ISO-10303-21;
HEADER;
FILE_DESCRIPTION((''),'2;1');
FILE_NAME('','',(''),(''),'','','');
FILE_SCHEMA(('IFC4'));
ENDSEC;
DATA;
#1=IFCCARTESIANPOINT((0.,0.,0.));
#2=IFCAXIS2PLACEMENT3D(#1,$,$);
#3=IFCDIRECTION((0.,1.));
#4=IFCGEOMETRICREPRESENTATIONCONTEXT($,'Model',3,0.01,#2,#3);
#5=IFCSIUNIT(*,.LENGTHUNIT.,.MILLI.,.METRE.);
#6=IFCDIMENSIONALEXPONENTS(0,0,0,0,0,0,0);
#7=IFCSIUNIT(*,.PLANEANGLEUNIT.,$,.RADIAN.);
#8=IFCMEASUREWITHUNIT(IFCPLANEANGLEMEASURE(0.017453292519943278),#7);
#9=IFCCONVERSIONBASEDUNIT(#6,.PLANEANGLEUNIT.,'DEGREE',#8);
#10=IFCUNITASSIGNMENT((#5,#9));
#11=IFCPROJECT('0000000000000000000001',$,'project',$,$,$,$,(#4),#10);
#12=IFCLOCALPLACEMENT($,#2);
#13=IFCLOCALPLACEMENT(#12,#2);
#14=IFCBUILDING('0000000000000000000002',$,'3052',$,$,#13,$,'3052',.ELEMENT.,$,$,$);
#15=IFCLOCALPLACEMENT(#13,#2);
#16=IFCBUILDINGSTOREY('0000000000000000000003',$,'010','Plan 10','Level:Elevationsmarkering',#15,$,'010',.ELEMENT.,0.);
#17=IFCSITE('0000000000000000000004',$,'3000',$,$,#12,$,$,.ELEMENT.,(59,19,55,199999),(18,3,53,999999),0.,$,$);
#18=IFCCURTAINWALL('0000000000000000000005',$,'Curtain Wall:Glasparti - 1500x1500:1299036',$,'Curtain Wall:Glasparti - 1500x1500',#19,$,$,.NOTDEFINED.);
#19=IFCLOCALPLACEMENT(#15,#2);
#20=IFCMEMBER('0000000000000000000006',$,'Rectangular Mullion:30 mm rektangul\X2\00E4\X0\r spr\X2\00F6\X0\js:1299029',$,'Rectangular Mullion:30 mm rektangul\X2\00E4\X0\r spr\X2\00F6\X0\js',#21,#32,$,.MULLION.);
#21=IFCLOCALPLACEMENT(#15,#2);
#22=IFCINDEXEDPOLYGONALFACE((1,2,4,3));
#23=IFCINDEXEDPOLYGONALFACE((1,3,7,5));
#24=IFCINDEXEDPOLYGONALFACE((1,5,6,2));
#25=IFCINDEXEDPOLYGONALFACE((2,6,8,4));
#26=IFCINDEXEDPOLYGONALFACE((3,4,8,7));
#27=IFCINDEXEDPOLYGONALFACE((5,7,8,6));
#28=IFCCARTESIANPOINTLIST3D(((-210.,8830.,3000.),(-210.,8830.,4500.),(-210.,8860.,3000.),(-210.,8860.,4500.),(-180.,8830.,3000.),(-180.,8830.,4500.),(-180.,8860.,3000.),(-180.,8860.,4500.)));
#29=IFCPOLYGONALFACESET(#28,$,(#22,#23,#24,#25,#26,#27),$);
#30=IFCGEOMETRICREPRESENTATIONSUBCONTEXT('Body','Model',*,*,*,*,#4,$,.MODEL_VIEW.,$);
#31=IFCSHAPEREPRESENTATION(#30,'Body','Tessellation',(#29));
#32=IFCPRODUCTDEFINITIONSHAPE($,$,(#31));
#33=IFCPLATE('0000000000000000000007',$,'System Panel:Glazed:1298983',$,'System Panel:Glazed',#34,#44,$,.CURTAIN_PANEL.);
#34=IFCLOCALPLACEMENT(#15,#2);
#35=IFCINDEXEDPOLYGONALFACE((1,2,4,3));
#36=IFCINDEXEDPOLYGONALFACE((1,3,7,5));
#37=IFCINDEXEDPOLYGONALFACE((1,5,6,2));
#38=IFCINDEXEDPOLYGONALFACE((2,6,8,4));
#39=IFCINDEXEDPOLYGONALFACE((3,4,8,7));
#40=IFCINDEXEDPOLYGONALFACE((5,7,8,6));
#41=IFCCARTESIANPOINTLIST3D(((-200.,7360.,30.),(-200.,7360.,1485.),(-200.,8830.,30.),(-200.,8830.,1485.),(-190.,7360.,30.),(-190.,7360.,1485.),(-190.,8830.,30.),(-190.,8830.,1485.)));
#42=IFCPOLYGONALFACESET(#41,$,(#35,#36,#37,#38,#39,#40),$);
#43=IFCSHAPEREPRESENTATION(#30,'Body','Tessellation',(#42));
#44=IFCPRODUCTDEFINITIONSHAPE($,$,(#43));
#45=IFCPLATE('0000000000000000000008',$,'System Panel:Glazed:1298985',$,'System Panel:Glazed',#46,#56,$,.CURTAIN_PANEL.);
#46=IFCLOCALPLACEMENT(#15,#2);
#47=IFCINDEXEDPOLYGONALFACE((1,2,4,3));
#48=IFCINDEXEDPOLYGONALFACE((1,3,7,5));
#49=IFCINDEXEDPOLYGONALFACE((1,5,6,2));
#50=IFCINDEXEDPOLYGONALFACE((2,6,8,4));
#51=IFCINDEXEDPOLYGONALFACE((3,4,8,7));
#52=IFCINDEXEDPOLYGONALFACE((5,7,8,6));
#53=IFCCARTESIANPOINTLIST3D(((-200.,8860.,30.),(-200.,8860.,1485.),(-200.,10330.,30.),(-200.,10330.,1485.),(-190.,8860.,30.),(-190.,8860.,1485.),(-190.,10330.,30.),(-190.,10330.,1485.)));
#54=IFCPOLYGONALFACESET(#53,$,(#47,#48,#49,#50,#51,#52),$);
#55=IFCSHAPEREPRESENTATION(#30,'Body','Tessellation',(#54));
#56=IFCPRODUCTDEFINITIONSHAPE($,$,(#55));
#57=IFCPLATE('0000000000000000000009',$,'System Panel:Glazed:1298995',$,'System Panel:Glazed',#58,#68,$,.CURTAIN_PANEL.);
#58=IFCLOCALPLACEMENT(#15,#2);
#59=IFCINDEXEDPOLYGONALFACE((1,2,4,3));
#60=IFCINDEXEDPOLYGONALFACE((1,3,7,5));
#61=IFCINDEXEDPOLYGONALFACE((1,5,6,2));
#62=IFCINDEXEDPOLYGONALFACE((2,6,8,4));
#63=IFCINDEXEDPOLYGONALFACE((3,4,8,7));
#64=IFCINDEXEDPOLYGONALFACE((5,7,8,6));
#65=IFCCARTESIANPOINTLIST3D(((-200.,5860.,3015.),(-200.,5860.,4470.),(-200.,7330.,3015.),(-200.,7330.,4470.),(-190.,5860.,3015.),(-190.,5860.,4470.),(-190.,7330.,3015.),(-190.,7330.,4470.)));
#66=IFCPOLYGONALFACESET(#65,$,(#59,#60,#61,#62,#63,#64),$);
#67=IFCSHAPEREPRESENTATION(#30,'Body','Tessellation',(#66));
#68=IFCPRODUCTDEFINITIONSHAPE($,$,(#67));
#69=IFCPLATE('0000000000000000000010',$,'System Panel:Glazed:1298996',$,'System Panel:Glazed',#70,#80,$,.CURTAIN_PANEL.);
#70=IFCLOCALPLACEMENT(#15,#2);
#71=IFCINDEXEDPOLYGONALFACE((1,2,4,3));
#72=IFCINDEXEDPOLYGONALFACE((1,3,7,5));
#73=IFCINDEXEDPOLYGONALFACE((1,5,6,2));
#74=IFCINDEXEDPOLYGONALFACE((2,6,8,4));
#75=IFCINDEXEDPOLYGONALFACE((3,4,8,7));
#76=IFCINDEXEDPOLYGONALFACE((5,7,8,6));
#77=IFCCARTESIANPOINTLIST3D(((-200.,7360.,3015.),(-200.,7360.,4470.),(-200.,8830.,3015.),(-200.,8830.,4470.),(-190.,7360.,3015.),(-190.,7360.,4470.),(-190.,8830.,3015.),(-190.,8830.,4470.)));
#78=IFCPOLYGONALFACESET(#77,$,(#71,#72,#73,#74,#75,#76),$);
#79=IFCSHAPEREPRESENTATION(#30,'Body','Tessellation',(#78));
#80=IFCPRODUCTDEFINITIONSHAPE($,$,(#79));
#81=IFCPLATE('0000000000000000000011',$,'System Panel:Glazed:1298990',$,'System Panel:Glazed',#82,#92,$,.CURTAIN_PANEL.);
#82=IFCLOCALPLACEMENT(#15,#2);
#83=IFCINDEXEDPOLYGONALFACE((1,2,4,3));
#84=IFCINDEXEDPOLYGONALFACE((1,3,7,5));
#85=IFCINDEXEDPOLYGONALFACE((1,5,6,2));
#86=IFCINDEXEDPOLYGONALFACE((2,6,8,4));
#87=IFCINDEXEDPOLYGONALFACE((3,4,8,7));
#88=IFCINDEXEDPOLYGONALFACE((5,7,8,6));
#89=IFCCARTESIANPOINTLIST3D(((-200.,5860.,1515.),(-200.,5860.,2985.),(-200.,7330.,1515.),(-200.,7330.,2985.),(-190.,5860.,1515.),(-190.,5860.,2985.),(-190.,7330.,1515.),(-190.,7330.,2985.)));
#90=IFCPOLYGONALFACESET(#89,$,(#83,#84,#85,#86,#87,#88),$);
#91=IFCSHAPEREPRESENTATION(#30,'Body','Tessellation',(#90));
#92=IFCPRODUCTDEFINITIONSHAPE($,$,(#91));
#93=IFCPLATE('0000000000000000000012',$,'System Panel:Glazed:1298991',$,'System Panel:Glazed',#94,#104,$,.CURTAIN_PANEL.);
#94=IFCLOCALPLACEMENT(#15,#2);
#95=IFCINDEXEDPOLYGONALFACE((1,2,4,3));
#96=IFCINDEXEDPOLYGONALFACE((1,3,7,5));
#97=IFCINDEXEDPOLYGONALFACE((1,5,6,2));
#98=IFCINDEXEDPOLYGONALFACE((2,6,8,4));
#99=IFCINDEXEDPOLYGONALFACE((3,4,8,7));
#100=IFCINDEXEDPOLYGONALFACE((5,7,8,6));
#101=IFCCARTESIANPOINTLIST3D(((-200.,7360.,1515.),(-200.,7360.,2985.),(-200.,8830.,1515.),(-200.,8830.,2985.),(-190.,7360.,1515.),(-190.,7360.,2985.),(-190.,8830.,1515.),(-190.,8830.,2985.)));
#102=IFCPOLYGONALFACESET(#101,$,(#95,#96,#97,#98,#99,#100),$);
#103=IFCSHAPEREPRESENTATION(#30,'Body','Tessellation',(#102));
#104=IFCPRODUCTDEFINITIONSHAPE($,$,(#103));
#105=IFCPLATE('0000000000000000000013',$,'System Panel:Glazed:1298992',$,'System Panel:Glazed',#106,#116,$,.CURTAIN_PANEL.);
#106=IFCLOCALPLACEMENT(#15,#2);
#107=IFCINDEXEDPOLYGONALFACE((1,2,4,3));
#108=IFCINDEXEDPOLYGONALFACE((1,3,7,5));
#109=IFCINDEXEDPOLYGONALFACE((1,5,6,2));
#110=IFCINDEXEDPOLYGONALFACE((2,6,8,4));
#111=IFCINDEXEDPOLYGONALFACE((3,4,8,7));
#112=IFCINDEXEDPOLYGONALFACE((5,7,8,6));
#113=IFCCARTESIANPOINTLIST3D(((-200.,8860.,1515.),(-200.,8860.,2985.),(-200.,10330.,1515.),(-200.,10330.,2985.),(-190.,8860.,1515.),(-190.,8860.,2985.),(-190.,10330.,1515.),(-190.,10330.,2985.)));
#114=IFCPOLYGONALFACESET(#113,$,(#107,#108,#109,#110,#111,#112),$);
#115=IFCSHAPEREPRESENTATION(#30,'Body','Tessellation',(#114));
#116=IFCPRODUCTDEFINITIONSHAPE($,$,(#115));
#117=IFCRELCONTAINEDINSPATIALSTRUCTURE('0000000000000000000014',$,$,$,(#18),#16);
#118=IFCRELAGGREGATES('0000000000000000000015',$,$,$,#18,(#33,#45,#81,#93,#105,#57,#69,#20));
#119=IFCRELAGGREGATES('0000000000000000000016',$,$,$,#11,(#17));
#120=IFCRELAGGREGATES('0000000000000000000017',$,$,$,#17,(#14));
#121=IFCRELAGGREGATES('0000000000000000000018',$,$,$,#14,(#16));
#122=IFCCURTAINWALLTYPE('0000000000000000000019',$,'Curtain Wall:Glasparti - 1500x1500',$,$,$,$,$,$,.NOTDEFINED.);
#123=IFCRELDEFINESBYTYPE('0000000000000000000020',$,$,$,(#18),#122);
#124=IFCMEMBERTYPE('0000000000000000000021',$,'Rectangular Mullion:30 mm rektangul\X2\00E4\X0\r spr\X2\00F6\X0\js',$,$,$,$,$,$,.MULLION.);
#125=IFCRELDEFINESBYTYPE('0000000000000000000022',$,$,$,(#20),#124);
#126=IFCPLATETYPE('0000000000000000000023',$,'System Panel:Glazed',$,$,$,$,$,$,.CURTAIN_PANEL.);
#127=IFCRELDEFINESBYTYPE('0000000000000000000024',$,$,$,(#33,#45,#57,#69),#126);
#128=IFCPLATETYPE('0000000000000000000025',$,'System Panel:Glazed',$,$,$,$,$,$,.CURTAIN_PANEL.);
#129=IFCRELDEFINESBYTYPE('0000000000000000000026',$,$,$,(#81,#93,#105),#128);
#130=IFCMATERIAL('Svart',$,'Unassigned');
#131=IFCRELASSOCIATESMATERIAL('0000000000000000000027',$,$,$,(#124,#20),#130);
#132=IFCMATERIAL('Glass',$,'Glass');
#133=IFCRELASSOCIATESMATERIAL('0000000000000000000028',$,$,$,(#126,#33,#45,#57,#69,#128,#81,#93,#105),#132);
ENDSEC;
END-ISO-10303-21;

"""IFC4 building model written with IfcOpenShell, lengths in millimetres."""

from ifc_helpers import new_model, entity, si_unit, converted_unit, direction, frame, origin, place, context, subcontext, project, spatial, indexed_curve, outline, extrude, source, transform, mapped, material, type_object, type_shapes, element, aggregate, save


model = new_model("IFC4")

# Units and contexts
model_context = context("Model", 3, precision=0.01, world=origin(), true_north=direction((0.0, 1.0)))
body_context = subcontext(model_context, "Body", "Model", "MODEL_VIEW")
ifc_project = project(units=[si_unit("LENGTHUNIT", "METRE", prefix="MILLI"), converted_unit("PLANEANGLEUNIT", "DEGREE", entity("IfcPlaneAngleMeasure", 0.017453292519943278), si_unit("PLANEANGLEUNIT", "RADIAN"), dimensions=[0, 0, 0, 0, 0, 0, 0])], contexts=[model_context])

# Site, building, storey
site_placement = place(None, origin())
site = spatial("IfcSite", under=ifc_project, at=site_placement, Name="3000", CompositionType="ELEMENT", RefLatitude=(59, 19, 55, 199999), RefLongitude=(18, 3, 53, 999999), RefElevation=0.0)
building_placement = place(site_placement, origin())
building = spatial("IfcBuilding", under=site, at=building_placement, Name="3052", LongName="3052", CompositionType="ELEMENT")
storey_placement = place(building_placement, origin())
storey = spatial("IfcBuildingStorey", under=building, at=storey_placement, Name="010", Description="Plan 10", ObjectType="Level:Elevationsmarkering", LongName="010", CompositionType="ELEMENT", Elevation=0.0)

# Curtain wall, member, plates
curtain_wall_type = type_object("IfcCurtainWallType", Name="Curtain Wall:Glasparti - 1500x1500", PredefinedType="NOTDEFINED")
curtain_wall_placement = place(storey_placement, origin())
curtain_wall = element("IfcCurtainWall", 1, at=curtain_wall_placement, inside=storey, type_object=curtain_wall_type, Name="Curtain Wall:Glasparti - 1500x1500:1299036", ObjectType="Curtain Wall:Glasparti - 1500x1500", PredefinedType="NOTDEFINED")
ifc_material_1 = material(Name="Svart", Category="Unassigned")
member_type_1 = type_object("IfcMemberType", Name="Rectangular Mullion:30 mm rektangulär spröjs", PredefinedType="MULLION", material=ifc_material_1)
shared_shape_1 = source(origin(), body_context, "Body", "SweptSolid", [
    extrude(outline(indexed_curve([(-15.0, -15.0), (15.0, -15.0), (15.0, 15.0), (-15.0, 15.0), (-15.0, -15.0)], self_intersect=False)), frame((0.0, 0.0, -1500.0), z_axis=(0.0, 0.0, 1.0), x_axis=(-1.0, 0.0, 0.0)), (0.0, 0.0, 1.0), 1500.0),
])
type_shapes(member_type_1, [shared_shape_1])
member_1_placement = place(curtain_wall_placement, frame((-195.0, 8845.0, 3000.0), z_axis=(0.0, 0.0, -1.0), x_axis=(0.0, 1.0, 0.0)))
member_1 = element("IfcMember", 2, at=member_1_placement, type_object=member_type_1, material=ifc_material_1, Name="Rectangular Mullion:30 mm rektangulär spröjs:1299029", ObjectType="Rectangular Mullion:30 mm rektangulär spröjs", PredefinedType="MULLION", context=body_context, shape_type="MappedRepresentation", body=[
    mapped(shared_shape_1, transform((0.0, 0.0, 0.0), scale=1.0)),
])
ifc_material_2 = material(Name="Glass", Category="Glass")
plate_type_1 = type_object("IfcPlateType", Name="System Panel:Glazed", PredefinedType="CURTAIN_PANEL", material=ifc_material_2)
shared_shape_2 = source(origin(), body_context, "Body", "SweptSolid", [
    extrude(outline(indexed_curve([(-5.0, -735.0), (5.0, -735.0), (5.0, 735.0), (-5.0, 735.0), (-5.0, -735.0)], self_intersect=False)), frame((0.0, 0.0, 0.0), z_axis=(0.0, 0.0, 1.0), x_axis=(0.0, 1.0, 0.0)), (0.0, 0.0, 1.0), 1455.0),
])
type_shapes(plate_type_1, [shared_shape_2])
plate_1_placement = place(curtain_wall_placement, frame((-195.0, 8095.0, 30.0), z_axis=(0.0, 0.0, 1.0), x_axis=(0.0, 1.0, 0.0)))
plate_1 = element("IfcPlate", 3, at=plate_1_placement, type_object=plate_type_1, material=ifc_material_2, Name="System Panel:Glazed:1298983", ObjectType="System Panel:Glazed", PredefinedType="CURTAIN_PANEL", context=body_context, shape_type="MappedRepresentation", body=[
    mapped(shared_shape_2, transform((0.0, 0.0, 0.0), scale=1.0)),
])
plate_2_placement = place(curtain_wall_placement, frame((-195.0, 9595.0, 30.0), z_axis=(0.0, 0.0, 1.0), x_axis=(0.0, 1.0, 0.0)))
plate_2 = element("IfcPlate", 4, at=plate_2_placement, type_object=plate_type_1, material=ifc_material_2, Name="System Panel:Glazed:1298985", ObjectType="System Panel:Glazed", PredefinedType="CURTAIN_PANEL", context=body_context, shape_type="MappedRepresentation", body=[
    mapped(shared_shape_2, transform((0.0, 0.0, 0.0), scale=1.0)),
])
plate_3_placement = place(curtain_wall_placement, frame((-195.0, 6595.0, 3015.0), z_axis=(0.0, 0.0, 1.0), x_axis=(0.0, 1.0, 0.0)))
plate_3 = element("IfcPlate", 5, at=plate_3_placement, type_object=plate_type_1, material=ifc_material_2, Name="System Panel:Glazed:1298995", ObjectType="System Panel:Glazed", PredefinedType="CURTAIN_PANEL", context=body_context, shape_type="MappedRepresentation", body=[
    mapped(shared_shape_2, transform((0.0, 0.0, 0.0), scale=1.0)),
])
plate_4_placement = place(curtain_wall_placement, frame((-195.0, 8095.0, 3015.0), z_axis=(0.0, 0.0, 1.0), x_axis=(0.0, 1.0, 0.0)))
plate_4 = element("IfcPlate", 6, at=plate_4_placement, type_object=plate_type_1, material=ifc_material_2, Name="System Panel:Glazed:1298996", ObjectType="System Panel:Glazed", PredefinedType="CURTAIN_PANEL", context=body_context, shape_type="MappedRepresentation", body=[
    mapped(shared_shape_2, transform((0.0, 0.0, 0.0), scale=1.0)),
])
plate_type_2 = type_object("IfcPlateType", Name="System Panel:Glazed", PredefinedType="CURTAIN_PANEL", material=ifc_material_2)
shared_shape_3 = source(origin(), body_context, "Body", "SweptSolid", [
    extrude(outline(indexed_curve([(-5.0, -735.0), (5.0, -735.0), (5.0, 735.0), (-5.0, 735.0), (-5.0, -735.0)], self_intersect=False)), frame((0.0, 0.0, 0.0), z_axis=(0.0, 0.0, 1.0), x_axis=(0.0, 1.0, 0.0)), (0.0, 0.0, 1.0), 1470.0),
])
type_shapes(plate_type_2, [shared_shape_3])
plate_5_placement = place(curtain_wall_placement, frame((-195.0, 6595.0, 1515.0), z_axis=(0.0, 0.0, 1.0), x_axis=(0.0, 1.0, 0.0)))
plate_5 = element("IfcPlate", 7, at=plate_5_placement, type_object=plate_type_2, material=ifc_material_2, Name="System Panel:Glazed:1298990", ObjectType="System Panel:Glazed", PredefinedType="CURTAIN_PANEL", context=body_context, shape_type="MappedRepresentation", body=[
    mapped(shared_shape_3, transform((0.0, 0.0, 0.0), scale=1.0)),
])
plate_6_placement = place(curtain_wall_placement, frame((-195.0, 8095.0, 1515.0), z_axis=(0.0, 0.0, 1.0), x_axis=(0.0, 1.0, 0.0)))
plate_6 = element("IfcPlate", 8, at=plate_6_placement, type_object=plate_type_2, material=ifc_material_2, Name="System Panel:Glazed:1298991", ObjectType="System Panel:Glazed", PredefinedType="CURTAIN_PANEL", context=body_context, shape_type="MappedRepresentation", body=[
    mapped(shared_shape_3, transform((0.0, 0.0, 0.0), scale=1.0)),
])
plate_7_placement = place(curtain_wall_placement, frame((-195.0, 9595.0, 1515.0), z_axis=(0.0, 0.0, 1.0), x_axis=(0.0, 1.0, 0.0)))
plate_7 = element("IfcPlate", 9, at=plate_7_placement, type_object=plate_type_2, material=ifc_material_2, Name="System Panel:Glazed:1298992", ObjectType="System Panel:Glazed", PredefinedType="CURTAIN_PANEL", context=body_context, shape_type="MappedRepresentation", body=[
    mapped(shared_shape_3, transform((0.0, 0.0, 0.0), scale=1.0)),
])
aggregate(curtain_wall, [plate_1, plate_2, plate_5, plate_6, plate_7, plate_3, plate_4, member_1])

save(model, "model.ifc")
